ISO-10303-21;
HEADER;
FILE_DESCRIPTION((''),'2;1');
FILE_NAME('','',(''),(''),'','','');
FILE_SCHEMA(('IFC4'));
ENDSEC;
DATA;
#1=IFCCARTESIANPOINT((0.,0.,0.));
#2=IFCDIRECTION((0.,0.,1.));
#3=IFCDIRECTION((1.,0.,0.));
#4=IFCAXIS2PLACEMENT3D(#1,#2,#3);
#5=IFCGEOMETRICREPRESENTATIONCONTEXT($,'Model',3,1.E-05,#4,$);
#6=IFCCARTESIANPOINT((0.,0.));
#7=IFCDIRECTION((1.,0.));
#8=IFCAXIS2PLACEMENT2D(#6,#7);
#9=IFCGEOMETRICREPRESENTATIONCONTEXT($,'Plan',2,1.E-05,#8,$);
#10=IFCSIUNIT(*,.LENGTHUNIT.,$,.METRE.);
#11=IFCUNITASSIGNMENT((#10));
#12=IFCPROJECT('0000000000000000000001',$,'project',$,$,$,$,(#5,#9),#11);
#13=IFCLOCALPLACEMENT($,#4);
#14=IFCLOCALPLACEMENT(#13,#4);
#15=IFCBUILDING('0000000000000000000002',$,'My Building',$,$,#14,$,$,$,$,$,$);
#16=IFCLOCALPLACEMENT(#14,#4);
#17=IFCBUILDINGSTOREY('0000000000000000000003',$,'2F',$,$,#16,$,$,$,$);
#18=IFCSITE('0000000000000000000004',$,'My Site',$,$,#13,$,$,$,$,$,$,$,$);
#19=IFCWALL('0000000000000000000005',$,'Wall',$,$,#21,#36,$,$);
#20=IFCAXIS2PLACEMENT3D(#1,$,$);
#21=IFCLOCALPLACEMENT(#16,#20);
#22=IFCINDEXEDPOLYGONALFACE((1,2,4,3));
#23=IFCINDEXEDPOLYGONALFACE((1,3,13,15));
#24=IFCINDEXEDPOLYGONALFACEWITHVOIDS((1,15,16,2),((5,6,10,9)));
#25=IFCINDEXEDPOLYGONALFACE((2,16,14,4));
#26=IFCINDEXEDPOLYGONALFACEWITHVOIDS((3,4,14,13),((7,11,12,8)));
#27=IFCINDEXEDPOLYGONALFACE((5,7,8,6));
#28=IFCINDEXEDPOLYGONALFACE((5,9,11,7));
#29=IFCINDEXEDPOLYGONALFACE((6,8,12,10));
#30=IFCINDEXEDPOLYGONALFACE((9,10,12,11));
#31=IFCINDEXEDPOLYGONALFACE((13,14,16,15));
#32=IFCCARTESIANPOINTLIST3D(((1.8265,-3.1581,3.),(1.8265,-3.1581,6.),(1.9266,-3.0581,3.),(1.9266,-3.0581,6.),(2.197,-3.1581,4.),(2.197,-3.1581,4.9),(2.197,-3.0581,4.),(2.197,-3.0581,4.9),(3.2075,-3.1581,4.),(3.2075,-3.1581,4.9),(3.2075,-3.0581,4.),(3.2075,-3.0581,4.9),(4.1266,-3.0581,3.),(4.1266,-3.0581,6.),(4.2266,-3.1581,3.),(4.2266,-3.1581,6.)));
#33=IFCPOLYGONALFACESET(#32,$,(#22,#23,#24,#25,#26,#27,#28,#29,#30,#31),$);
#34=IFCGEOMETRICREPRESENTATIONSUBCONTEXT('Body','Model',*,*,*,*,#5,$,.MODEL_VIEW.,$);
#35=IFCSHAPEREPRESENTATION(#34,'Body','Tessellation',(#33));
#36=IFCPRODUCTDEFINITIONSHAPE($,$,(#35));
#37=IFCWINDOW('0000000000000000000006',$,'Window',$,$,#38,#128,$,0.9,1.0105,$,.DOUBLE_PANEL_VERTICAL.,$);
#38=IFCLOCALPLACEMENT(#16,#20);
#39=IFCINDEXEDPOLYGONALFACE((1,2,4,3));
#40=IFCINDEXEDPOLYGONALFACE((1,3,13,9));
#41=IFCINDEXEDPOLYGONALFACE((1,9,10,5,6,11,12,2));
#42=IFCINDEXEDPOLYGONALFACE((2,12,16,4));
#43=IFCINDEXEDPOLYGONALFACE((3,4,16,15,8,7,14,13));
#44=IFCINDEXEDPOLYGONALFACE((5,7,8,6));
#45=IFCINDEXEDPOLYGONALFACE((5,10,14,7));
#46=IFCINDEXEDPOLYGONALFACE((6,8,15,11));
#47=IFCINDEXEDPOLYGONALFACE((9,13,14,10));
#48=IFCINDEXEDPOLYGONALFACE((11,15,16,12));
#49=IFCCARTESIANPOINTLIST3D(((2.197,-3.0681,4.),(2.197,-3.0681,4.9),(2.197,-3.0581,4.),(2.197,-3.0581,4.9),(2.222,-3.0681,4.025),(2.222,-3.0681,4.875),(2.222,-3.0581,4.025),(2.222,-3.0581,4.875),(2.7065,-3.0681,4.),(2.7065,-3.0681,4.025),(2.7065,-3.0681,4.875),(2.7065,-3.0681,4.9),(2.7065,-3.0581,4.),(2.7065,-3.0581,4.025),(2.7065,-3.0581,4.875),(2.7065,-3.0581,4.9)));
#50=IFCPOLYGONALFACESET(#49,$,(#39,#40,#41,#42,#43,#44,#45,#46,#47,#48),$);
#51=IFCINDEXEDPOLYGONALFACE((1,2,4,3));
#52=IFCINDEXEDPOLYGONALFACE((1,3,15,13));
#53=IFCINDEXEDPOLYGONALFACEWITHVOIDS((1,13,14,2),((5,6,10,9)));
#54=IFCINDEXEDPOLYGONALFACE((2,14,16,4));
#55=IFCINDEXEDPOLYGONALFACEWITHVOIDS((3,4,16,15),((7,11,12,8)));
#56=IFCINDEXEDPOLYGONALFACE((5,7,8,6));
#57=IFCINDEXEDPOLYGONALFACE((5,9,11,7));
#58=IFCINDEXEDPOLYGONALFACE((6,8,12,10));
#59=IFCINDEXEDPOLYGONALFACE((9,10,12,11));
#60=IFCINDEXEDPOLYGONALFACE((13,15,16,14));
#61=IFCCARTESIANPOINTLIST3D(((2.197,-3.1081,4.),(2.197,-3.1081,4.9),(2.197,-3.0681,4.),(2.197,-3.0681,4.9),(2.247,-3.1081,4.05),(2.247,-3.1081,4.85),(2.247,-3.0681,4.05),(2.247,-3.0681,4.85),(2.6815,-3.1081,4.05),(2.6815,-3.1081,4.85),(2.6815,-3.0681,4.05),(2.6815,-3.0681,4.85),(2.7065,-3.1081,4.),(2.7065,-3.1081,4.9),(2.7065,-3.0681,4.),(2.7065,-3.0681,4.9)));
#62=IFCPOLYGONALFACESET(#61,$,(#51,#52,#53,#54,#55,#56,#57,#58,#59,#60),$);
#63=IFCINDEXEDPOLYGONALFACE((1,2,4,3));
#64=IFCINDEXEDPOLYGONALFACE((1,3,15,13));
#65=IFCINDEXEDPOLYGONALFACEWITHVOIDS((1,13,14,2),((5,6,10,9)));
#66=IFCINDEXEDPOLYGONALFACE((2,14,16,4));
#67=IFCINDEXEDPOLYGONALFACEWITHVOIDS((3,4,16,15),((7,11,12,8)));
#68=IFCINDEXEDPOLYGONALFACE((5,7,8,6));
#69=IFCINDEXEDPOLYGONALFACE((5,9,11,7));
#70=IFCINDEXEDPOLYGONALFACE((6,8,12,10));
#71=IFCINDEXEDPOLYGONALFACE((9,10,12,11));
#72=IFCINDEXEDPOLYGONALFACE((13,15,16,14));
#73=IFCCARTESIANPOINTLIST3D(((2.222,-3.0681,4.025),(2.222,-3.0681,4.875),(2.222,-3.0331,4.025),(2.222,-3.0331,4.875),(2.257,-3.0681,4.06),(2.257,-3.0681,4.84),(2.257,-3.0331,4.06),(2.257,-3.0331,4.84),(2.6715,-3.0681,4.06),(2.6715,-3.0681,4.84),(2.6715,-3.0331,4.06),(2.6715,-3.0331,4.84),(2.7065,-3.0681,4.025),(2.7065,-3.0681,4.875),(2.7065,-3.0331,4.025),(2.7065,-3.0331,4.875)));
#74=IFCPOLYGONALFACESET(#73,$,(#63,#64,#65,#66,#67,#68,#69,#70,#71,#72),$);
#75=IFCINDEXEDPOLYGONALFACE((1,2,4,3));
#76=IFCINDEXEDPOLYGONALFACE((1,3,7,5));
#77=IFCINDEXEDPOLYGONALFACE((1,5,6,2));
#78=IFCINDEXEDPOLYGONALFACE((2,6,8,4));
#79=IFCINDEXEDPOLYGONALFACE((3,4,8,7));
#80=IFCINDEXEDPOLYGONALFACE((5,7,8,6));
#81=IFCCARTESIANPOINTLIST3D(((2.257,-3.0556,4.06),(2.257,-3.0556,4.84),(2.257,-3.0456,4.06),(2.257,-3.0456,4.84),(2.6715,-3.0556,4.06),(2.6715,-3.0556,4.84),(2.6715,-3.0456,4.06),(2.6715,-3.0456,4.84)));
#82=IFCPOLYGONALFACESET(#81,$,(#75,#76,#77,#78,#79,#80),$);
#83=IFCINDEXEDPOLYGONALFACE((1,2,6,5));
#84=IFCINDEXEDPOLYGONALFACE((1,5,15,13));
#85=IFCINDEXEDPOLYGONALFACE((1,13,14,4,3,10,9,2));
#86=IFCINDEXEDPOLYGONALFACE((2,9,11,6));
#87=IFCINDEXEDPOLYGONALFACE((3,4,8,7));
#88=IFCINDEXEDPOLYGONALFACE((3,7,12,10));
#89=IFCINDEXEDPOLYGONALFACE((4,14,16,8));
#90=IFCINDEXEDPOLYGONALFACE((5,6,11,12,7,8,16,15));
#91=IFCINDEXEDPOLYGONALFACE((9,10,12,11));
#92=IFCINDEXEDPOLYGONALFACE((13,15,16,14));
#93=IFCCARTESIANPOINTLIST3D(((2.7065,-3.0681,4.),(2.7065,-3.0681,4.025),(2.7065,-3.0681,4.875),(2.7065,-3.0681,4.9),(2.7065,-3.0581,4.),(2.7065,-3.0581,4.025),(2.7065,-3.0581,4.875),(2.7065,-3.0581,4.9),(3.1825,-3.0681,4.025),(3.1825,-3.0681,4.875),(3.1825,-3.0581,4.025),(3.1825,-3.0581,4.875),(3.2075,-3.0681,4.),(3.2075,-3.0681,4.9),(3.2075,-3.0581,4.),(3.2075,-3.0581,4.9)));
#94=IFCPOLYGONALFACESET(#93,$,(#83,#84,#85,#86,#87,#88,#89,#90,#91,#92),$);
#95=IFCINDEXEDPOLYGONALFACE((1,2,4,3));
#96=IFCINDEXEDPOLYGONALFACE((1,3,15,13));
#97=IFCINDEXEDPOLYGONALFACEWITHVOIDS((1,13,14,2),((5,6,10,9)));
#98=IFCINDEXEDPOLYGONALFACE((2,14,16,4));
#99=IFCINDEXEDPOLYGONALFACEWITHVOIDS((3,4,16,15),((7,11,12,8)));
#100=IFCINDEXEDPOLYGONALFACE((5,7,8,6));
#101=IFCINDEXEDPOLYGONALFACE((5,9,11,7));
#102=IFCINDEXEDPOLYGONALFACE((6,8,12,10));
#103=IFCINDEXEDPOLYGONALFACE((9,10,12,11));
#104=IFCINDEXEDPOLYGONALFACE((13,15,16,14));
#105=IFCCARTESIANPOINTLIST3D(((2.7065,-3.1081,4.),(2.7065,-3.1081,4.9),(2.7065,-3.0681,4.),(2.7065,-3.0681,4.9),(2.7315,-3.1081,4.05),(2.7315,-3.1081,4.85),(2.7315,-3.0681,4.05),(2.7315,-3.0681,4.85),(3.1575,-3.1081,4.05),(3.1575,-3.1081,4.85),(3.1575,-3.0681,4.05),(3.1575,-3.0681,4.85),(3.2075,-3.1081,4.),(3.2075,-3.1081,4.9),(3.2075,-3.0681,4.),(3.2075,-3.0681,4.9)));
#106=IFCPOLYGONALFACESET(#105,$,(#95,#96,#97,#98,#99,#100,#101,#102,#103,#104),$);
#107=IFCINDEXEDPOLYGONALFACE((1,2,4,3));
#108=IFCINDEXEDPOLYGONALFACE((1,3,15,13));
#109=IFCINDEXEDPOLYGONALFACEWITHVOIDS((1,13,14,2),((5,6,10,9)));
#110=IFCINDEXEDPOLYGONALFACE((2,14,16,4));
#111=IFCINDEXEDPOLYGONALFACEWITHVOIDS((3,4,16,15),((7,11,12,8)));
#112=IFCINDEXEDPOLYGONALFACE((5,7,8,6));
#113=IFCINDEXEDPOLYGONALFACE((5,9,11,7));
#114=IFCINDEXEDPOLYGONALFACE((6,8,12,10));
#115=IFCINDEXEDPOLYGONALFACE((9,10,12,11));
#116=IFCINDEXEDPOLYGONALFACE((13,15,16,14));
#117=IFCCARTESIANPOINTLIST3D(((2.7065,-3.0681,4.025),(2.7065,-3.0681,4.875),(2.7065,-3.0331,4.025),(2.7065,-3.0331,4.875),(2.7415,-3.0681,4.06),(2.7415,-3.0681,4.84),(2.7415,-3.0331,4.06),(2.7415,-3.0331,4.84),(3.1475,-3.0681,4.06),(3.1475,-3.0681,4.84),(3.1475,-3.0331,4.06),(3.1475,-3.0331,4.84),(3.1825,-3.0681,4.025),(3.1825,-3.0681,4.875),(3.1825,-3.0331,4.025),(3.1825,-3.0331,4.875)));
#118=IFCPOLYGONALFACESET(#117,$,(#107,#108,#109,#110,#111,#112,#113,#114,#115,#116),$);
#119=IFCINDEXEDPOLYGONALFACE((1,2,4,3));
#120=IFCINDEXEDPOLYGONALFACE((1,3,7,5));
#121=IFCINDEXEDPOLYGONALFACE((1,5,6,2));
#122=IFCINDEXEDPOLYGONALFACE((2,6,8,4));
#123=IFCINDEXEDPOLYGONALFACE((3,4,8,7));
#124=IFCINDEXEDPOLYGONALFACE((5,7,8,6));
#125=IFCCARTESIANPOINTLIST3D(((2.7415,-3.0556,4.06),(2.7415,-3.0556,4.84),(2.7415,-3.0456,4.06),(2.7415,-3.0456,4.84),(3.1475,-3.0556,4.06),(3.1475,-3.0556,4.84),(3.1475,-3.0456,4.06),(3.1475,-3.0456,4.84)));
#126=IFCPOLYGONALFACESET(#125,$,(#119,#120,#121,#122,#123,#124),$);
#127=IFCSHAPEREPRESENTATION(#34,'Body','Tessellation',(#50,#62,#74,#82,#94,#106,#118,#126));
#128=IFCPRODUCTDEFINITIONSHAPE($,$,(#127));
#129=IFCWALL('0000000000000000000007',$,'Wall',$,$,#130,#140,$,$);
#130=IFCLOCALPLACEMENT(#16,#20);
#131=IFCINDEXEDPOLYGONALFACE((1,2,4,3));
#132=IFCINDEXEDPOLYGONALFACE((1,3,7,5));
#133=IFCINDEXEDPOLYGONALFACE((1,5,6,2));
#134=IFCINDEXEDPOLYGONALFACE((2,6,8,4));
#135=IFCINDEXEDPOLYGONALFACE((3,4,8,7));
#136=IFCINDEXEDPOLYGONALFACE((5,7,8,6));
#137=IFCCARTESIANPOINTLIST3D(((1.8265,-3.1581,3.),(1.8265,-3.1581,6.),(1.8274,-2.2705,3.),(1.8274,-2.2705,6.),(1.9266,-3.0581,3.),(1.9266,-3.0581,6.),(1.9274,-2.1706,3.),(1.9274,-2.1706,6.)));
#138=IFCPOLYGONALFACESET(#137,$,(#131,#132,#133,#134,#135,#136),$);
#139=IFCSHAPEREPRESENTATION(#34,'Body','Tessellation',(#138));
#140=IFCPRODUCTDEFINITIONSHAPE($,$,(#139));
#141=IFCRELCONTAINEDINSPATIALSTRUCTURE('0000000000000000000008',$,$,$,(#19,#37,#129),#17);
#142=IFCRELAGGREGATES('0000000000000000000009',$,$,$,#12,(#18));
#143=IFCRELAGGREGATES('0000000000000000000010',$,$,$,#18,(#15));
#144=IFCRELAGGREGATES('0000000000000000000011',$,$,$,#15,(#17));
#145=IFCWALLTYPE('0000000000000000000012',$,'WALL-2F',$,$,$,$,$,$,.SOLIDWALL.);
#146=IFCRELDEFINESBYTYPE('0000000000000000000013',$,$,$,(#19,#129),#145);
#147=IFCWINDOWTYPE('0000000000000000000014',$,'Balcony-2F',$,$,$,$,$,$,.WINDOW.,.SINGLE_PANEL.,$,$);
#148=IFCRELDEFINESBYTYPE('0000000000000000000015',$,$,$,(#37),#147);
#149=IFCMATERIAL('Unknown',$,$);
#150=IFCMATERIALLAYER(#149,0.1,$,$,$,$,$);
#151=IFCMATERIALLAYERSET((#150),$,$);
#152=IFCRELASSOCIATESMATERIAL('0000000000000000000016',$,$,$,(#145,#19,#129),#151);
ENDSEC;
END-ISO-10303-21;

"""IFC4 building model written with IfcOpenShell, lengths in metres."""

from ifc_helpers import new_model, entity, si_unit, frame, origin_with_axes, origin_2d_with_axis, place, context, subcontext, project, spatial, line, indexed_curve, outline, extrude, shape, source, transform, mapped, material, layer, layer_set, layer_usage, type_object, type_shapes, element, fill, save


model = new_model("IFC4")

# Units and contexts
model_context = context("Model", 3, precision=1e-05, world=origin_with_axes())
plan_context = context("Plan", 2, precision=1e-05, world=origin_2d_with_axis())
body_context_1 = subcontext(model_context, "Body", "Model", "MODEL_VIEW")
body_context_2 = subcontext(plan_context, "Body", "Plan", "PLAN_VIEW")
ifc_project = project(units=[si_unit("LENGTHUNIT", "METRE")], contexts=[model_context, plan_context])

# Site, building, storey
site_placement = place(None, origin_with_axes())
site = spatial("IfcSite", under=ifc_project, at=site_placement, Name="My Site")
building_placement = place(site_placement, origin_with_axes())
building = spatial("IfcBuilding", under=site, at=building_placement, Name="My Building")
storey_placement = place(building_placement, origin_with_axes())
storey = spatial("IfcBuildingStorey", under=building, at=storey_placement, Name="2F")

# Shared definitions
ifc_material = material(Name="Unknown")

# Shared definitions
ifc_layer_1 = layer(ifc_material, 0.1)
ifc_layer_set_1 = layer_set([ifc_layer_1])
wall_type_1 = type_object("IfcWallType", Name="WALL-2F", PredefinedType="SOLIDWALL", material=ifc_layer_set_1)

# Wall, opening, window
ifc_layer_usage_1 = layer_usage(ifc_layer_set_1, "AXIS2", "POSITIVE", 0.0)
wall_1_placement = place(storey_placement, frame((4.1266, -3.0581, 3.0), z_axis=(0.0, 0.0, 1.0), x_axis=(-1.0, 0.0, 0.0)))
wall_1 = element("IfcWall", 1, at=wall_1_placement, inside=storey, type_object=wall_type_1, material=ifc_layer_usage_1, Name="Wall", context=body_context_1, shape_type="SweptSolid", body=[
    extrude(outline(indexed_curve([(0.0, 0.0), (-0.1, 0.1), (2.3001, 0.1), (2.2, 0.0)], segments=[line(1, 2, 3, 4, 1)])), origin_with_axes(), (0.0, 0.0, 1.0), 3.0),
])
shared_shape_1 = source(origin_with_axes(), body_context_1, "Body", "SweptSolid", [
    extrude(outline(indexed_curve([(0.0, 0.0), (1.0105, 0.0), (1.0105, 0.9), (0.0, 0.9)], segments=[line(1, 2, 3, 4, 1)])), frame((0.0, -0.6, 0.0), z_axis=(0.0, -1.0, 0.0), x_axis=(1.0, 0.0, 0.0)), (0.0, 0.0, -1.0), 1.2),
])
opening_1_placement = place(wall_1_placement, frame((1.9296, 0.1, 1.0), z_axis=(0.0, 0.0, 1.0), x_axis=(-1.0, 0.0, 0.0)))
opening_1 = element("IfcOpeningElement", 2, at=opening_1_placement, cuts=wall_1, PredefinedType="OPENING", context=body_context_1, shape_type="MappedRepresentation", body=[
    mapped(shared_shape_1, transform((0.0, 0.0, 0.0), x_axis=(1.0, 0.0, 0.0), y_axis=(0.0, 1.0, 0.0), z_axis=(0.0, 0.0, 1.0), scale=1.0)),
])
window_type_1 = type_object("IfcWindowType", Name="Balcony-2F", PartitioningType="SINGLE_PANEL", PredefinedType="WINDOW")
shared_shape_2 = source(origin_with_axes(), body_context_1, "Body", "SweptSolid", [
    extrude(outline(indexed_curve([(0.5096, 0.0), (0.0, 0.0), (0.0, 0.9), (0.5096, 0.9), (0.5096, 0.875), (0.025, 0.875), (0.025, 0.025), (0.5096, 0.025)], segments=[line(1, 2, 3, 4, 5, 6, 7, 8, 1)])), frame((0.0, 0.09, 0.0), z_axis=(0.0, -1.0, 0.0), x_axis=(1.0, 0.0, 0.0)), (0.0, 0.0, -1.0), 0.01),
    extrude(outline(indexed_curve([(0.0, 0.0), (0.5096, 0.0), (0.5096, 0.9), (0.0, 0.9)], segments=[line(1, 2, 3, 4, 1)]), holes=[indexed_curve([(0.05, 0.05), (0.4846, 0.05), (0.4846, 0.85), (0.05, 0.85)], segments=[line(1, 2, 3, 4, 1)])]), frame((0.0, 0.05, 0.0), z_axis=(0.0, -1.0, 0.0), x_axis=(1.0, 0.0, 0.0)), (0.0, 0.0, -1.0), 0.04),
    extrude(outline(indexed_curve([(0.0, 0.0), (0.4846, 0.0), (0.4846, 0.85), (0.0, 0.85)], segments=[line(1, 2, 3, 4, 1)]), holes=[indexed_curve([(0.035, 0.035), (0.4496, 0.035), (0.4496, 0.815), (0.035, 0.815)], segments=[line(1, 2, 3, 4, 1)])]), frame((0.025, 0.09, 0.025), z_axis=(0.0, -1.0, 0.0), x_axis=(1.0, 0.0, 0.0)), (0.0, 0.0, -1.0), 0.035),
    extrude(outline(indexed_curve([(0.035, 0.035), (0.4496, 0.035), (0.4496, 0.815), (0.035, 0.815)], segments=[line(1, 2, 3, 4, 1)])), frame((0.025, 0.1025, 0.025), z_axis=(0.0, -1.0, 0.0), x_axis=(1.0, 0.0, 0.0)), (0.0, 0.0, -1.0), 0.01),
    extrude(outline(indexed_curve([(0.0, 0.9), (0.501, 0.9), (0.501, 0.0), (0.0, 0.0), (0.0, 0.025), (0.476, 0.025), (0.476, 0.875), (0.0, 0.875)], segments=[line(1, 2, 3, 4, 5, 6, 7, 8, 1)])), frame((0.5096, 0.09, 0.0), z_axis=(0.0, -1.0, 0.0), x_axis=(1.0, 0.0, 0.0)), (0.0, 0.0, -1.0), 0.01),
    extrude(outline(indexed_curve([(0.0, 0.0), (0.501, 0.0), (0.501, 0.9), (0.0, 0.9)], segments=[line(1, 2, 3, 4, 1)]), holes=[indexed_curve([(0.025, 0.05), (0.451, 0.05), (0.451, 0.85), (0.025, 0.85)], segments=[line(1, 2, 3, 4, 1)])]), frame((0.5096, 0.05, 0.0), z_axis=(0.0, -1.0, 0.0), x_axis=(1.0, 0.0, 0.0)), (0.0, 0.0, -1.0), 0.04),
    extrude(outline(indexed_curve([(0.0, 0.0), (0.476, 0.0), (0.476, 0.85), (0.0, 0.85)], segments=[line(1, 2, 3, 4, 1)]), holes=[indexed_curve([(0.035, 0.035), (0.441, 0.035), (0.441, 0.815), (0.035, 0.815)], segments=[line(1, 2, 3, 4, 1)])]), frame((0.5096, 0.09, 0.025), z_axis=(0.0, -1.0, 0.0), x_axis=(1.0, 0.0, 0.0)), (0.0, 0.0, -1.0), 0.035),
    extrude(outline(indexed_curve([(0.035, 0.035), (0.441, 0.035), (0.441, 0.815), (0.035, 0.815)], segments=[line(1, 2, 3, 4, 1)])), frame((0.5096, 0.1025, 0.025), z_axis=(0.0, -1.0, 0.0), x_axis=(1.0, 0.0, 0.0)), (0.0, 0.0, -1.0), 0.01),
])
shared_shape_3 = source(origin_with_axes(), body_context_2, "Body", "Curve2D", [
    entity("IfcIndexedPolyCurve", entity("IfcCartesianPointList2D", [[0.05, 0.05], [0.4846, 0.05]])),
    entity("IfcIndexedPolyCurve", entity("IfcCartesianPointList2D", [[0.0, 0.1], [0.025, 0.1], [0.025, 0.09], [0.05, 0.09], [0.05, 0.05], [0.0, 0.05]]), [entity("IfcLineIndex", [1, 2, 3, 4, 5, 6, 1])]),
    entity("IfcIndexedPolyCurve", entity("IfcCartesianPointList2D", [[0.5096, 0.1], [0.5096, 0.1], [0.5096, 0.09], [0.4846, 0.09], [0.4846, 0.05], [0.5096, 0.05]])),
    entity("IfcIndexedPolyCurve", entity("IfcCartesianPointList2D", [[0.025, 0.09], [0.06, 0.09], [0.06, 0.125], [0.025, 0.125]]), [entity("IfcLineIndex", [1, 2, 3, 4, 1])]),
    entity("IfcIndexedPolyCurve", entity("IfcCartesianPointList2D", [[0.5096, 0.09], [0.4746, 0.09], [0.4746, 0.125], [0.5096, 0.125]]), [entity("IfcLineIndex", [1, 2, 3, 4, 1])]),
    entity("IfcIndexedPolyCurve", entity("IfcCartesianPointList2D", [[0.06, 0.09], [0.4746, 0.09]])),
    entity("IfcIndexedPolyCurve", entity("IfcCartesianPointList2D", [[0.06, 0.125], [0.4746, 0.125]])),
    entity("IfcIndexedPolyCurve", entity("IfcCartesianPointList2D", [[0.06, 0.1075], [0.4746, 0.1075]])),
    entity("IfcIndexedPolyCurve", entity("IfcCartesianPointList2D", [[0.5346, 0.05], [0.9605, 0.05]])),
    entity("IfcIndexedPolyCurve", entity("IfcCartesianPointList2D", [[0.5096, 0.1], [0.5096, 0.1], [0.5096, 0.09], [0.5346, 0.09], [0.5346, 0.05], [0.5096, 0.05]])),
    entity("IfcIndexedPolyCurve", entity("IfcCartesianPointList2D", [[1.0105, 0.1], [0.9855, 0.1], [0.9855, 0.09], [0.9605, 0.09], [0.9605, 0.05], [1.0105, 0.05]]), [entity("IfcLineIndex", [1, 2, 3, 4, 5, 6, 1])]),
    entity("IfcIndexedPolyCurve", entity("IfcCartesianPointList2D", [[0.5096, 0.09], [0.5446, 0.09], [0.5446, 0.125], [0.5096, 0.125]]), [entity("IfcLineIndex", [1, 2, 3, 4, 1])]),
    entity("IfcIndexedPolyCurve", entity("IfcCartesianPointList2D", [[0.9855, 0.09], [0.9505, 0.09], [0.9505, 0.125], [0.9855, 0.125]]), [entity("IfcLineIndex", [1, 2, 3, 4, 1])]),
    entity("IfcIndexedPolyCurve", entity("IfcCartesianPointList2D", [[0.5446, 0.09], [0.9505, 0.09]])),
    entity("IfcIndexedPolyCurve", entity("IfcCartesianPointList2D", [[0.5446, 0.125], [0.9505, 0.125]])),
    entity("IfcIndexedPolyCurve", entity("IfcCartesianPointList2D", [[0.5446, 0.1075], [0.9505, 0.1075]])),
])
type_shapes(window_type_1, [shared_shape_2, shared_shape_3])
window_1_placement = place(opening_1_placement, frame((0.0, 0.0, 0.0), z_axis=(0.0, 0.0, 1.0), x_axis=(1.0, 0.0, 0.0)))
window_1 = element("IfcWindow", 3, at=window_1_placement, inside=storey, type_object=window_type_1, Name="Window", OverallHeight=0.9, OverallWidth=1.0105, PartitioningType="DOUBLE_PANEL_VERTICAL", shapes=[
    shape(body_context_1, "Body", "MappedRepresentation", [mapped(shared_shape_2, transform((0.0, 0.0, 0.0), x_axis=(1.0, 0.0, 0.0), y_axis=(0.0, 1.0, 0.0), z_axis=(0.0, 0.0, 1.0), scale=1.0))]),
    shape(body_context_2, "Body", "MappedRepresentation", [mapped(shared_shape_3, transform((0.0, 0.0, 0.0), x_axis=(1.0, 0.0, 0.0), y_axis=(0.0, 1.0, 0.0), z_axis=(0.0, 0.0, 1.0), scale=1.0))]),
])
fill(opening_1, window_1)

# Wall
ifc_layer_usage_2 = layer_usage(ifc_layer_set_1, "AXIS2", "POSITIVE", 0.0)
wall_2_placement = place(storey_placement, frame((1.9266, -3.0581, 3.0), z_axis=(0.0, 0.0, 1.0), x_axis=(0.000947, 1.0, 0.0)))
element("IfcWall", 4, at=wall_2_placement, inside=storey, type_object=wall_type_1, material=ifc_layer_usage_2, Name="Wall", context=body_context_1, shape_type="SweptSolid", body=[
    extrude(outline(indexed_curve([(0.0, 0.0), (-0.1001, 0.1), (0.7875, 0.1), (0.8875, 0.0)], segments=[line(1, 2, 3, 4, 1)])), origin_with_axes(), (0.0, 0.0, 1.0), 3.0),
])

save(model, "model.ifc")
